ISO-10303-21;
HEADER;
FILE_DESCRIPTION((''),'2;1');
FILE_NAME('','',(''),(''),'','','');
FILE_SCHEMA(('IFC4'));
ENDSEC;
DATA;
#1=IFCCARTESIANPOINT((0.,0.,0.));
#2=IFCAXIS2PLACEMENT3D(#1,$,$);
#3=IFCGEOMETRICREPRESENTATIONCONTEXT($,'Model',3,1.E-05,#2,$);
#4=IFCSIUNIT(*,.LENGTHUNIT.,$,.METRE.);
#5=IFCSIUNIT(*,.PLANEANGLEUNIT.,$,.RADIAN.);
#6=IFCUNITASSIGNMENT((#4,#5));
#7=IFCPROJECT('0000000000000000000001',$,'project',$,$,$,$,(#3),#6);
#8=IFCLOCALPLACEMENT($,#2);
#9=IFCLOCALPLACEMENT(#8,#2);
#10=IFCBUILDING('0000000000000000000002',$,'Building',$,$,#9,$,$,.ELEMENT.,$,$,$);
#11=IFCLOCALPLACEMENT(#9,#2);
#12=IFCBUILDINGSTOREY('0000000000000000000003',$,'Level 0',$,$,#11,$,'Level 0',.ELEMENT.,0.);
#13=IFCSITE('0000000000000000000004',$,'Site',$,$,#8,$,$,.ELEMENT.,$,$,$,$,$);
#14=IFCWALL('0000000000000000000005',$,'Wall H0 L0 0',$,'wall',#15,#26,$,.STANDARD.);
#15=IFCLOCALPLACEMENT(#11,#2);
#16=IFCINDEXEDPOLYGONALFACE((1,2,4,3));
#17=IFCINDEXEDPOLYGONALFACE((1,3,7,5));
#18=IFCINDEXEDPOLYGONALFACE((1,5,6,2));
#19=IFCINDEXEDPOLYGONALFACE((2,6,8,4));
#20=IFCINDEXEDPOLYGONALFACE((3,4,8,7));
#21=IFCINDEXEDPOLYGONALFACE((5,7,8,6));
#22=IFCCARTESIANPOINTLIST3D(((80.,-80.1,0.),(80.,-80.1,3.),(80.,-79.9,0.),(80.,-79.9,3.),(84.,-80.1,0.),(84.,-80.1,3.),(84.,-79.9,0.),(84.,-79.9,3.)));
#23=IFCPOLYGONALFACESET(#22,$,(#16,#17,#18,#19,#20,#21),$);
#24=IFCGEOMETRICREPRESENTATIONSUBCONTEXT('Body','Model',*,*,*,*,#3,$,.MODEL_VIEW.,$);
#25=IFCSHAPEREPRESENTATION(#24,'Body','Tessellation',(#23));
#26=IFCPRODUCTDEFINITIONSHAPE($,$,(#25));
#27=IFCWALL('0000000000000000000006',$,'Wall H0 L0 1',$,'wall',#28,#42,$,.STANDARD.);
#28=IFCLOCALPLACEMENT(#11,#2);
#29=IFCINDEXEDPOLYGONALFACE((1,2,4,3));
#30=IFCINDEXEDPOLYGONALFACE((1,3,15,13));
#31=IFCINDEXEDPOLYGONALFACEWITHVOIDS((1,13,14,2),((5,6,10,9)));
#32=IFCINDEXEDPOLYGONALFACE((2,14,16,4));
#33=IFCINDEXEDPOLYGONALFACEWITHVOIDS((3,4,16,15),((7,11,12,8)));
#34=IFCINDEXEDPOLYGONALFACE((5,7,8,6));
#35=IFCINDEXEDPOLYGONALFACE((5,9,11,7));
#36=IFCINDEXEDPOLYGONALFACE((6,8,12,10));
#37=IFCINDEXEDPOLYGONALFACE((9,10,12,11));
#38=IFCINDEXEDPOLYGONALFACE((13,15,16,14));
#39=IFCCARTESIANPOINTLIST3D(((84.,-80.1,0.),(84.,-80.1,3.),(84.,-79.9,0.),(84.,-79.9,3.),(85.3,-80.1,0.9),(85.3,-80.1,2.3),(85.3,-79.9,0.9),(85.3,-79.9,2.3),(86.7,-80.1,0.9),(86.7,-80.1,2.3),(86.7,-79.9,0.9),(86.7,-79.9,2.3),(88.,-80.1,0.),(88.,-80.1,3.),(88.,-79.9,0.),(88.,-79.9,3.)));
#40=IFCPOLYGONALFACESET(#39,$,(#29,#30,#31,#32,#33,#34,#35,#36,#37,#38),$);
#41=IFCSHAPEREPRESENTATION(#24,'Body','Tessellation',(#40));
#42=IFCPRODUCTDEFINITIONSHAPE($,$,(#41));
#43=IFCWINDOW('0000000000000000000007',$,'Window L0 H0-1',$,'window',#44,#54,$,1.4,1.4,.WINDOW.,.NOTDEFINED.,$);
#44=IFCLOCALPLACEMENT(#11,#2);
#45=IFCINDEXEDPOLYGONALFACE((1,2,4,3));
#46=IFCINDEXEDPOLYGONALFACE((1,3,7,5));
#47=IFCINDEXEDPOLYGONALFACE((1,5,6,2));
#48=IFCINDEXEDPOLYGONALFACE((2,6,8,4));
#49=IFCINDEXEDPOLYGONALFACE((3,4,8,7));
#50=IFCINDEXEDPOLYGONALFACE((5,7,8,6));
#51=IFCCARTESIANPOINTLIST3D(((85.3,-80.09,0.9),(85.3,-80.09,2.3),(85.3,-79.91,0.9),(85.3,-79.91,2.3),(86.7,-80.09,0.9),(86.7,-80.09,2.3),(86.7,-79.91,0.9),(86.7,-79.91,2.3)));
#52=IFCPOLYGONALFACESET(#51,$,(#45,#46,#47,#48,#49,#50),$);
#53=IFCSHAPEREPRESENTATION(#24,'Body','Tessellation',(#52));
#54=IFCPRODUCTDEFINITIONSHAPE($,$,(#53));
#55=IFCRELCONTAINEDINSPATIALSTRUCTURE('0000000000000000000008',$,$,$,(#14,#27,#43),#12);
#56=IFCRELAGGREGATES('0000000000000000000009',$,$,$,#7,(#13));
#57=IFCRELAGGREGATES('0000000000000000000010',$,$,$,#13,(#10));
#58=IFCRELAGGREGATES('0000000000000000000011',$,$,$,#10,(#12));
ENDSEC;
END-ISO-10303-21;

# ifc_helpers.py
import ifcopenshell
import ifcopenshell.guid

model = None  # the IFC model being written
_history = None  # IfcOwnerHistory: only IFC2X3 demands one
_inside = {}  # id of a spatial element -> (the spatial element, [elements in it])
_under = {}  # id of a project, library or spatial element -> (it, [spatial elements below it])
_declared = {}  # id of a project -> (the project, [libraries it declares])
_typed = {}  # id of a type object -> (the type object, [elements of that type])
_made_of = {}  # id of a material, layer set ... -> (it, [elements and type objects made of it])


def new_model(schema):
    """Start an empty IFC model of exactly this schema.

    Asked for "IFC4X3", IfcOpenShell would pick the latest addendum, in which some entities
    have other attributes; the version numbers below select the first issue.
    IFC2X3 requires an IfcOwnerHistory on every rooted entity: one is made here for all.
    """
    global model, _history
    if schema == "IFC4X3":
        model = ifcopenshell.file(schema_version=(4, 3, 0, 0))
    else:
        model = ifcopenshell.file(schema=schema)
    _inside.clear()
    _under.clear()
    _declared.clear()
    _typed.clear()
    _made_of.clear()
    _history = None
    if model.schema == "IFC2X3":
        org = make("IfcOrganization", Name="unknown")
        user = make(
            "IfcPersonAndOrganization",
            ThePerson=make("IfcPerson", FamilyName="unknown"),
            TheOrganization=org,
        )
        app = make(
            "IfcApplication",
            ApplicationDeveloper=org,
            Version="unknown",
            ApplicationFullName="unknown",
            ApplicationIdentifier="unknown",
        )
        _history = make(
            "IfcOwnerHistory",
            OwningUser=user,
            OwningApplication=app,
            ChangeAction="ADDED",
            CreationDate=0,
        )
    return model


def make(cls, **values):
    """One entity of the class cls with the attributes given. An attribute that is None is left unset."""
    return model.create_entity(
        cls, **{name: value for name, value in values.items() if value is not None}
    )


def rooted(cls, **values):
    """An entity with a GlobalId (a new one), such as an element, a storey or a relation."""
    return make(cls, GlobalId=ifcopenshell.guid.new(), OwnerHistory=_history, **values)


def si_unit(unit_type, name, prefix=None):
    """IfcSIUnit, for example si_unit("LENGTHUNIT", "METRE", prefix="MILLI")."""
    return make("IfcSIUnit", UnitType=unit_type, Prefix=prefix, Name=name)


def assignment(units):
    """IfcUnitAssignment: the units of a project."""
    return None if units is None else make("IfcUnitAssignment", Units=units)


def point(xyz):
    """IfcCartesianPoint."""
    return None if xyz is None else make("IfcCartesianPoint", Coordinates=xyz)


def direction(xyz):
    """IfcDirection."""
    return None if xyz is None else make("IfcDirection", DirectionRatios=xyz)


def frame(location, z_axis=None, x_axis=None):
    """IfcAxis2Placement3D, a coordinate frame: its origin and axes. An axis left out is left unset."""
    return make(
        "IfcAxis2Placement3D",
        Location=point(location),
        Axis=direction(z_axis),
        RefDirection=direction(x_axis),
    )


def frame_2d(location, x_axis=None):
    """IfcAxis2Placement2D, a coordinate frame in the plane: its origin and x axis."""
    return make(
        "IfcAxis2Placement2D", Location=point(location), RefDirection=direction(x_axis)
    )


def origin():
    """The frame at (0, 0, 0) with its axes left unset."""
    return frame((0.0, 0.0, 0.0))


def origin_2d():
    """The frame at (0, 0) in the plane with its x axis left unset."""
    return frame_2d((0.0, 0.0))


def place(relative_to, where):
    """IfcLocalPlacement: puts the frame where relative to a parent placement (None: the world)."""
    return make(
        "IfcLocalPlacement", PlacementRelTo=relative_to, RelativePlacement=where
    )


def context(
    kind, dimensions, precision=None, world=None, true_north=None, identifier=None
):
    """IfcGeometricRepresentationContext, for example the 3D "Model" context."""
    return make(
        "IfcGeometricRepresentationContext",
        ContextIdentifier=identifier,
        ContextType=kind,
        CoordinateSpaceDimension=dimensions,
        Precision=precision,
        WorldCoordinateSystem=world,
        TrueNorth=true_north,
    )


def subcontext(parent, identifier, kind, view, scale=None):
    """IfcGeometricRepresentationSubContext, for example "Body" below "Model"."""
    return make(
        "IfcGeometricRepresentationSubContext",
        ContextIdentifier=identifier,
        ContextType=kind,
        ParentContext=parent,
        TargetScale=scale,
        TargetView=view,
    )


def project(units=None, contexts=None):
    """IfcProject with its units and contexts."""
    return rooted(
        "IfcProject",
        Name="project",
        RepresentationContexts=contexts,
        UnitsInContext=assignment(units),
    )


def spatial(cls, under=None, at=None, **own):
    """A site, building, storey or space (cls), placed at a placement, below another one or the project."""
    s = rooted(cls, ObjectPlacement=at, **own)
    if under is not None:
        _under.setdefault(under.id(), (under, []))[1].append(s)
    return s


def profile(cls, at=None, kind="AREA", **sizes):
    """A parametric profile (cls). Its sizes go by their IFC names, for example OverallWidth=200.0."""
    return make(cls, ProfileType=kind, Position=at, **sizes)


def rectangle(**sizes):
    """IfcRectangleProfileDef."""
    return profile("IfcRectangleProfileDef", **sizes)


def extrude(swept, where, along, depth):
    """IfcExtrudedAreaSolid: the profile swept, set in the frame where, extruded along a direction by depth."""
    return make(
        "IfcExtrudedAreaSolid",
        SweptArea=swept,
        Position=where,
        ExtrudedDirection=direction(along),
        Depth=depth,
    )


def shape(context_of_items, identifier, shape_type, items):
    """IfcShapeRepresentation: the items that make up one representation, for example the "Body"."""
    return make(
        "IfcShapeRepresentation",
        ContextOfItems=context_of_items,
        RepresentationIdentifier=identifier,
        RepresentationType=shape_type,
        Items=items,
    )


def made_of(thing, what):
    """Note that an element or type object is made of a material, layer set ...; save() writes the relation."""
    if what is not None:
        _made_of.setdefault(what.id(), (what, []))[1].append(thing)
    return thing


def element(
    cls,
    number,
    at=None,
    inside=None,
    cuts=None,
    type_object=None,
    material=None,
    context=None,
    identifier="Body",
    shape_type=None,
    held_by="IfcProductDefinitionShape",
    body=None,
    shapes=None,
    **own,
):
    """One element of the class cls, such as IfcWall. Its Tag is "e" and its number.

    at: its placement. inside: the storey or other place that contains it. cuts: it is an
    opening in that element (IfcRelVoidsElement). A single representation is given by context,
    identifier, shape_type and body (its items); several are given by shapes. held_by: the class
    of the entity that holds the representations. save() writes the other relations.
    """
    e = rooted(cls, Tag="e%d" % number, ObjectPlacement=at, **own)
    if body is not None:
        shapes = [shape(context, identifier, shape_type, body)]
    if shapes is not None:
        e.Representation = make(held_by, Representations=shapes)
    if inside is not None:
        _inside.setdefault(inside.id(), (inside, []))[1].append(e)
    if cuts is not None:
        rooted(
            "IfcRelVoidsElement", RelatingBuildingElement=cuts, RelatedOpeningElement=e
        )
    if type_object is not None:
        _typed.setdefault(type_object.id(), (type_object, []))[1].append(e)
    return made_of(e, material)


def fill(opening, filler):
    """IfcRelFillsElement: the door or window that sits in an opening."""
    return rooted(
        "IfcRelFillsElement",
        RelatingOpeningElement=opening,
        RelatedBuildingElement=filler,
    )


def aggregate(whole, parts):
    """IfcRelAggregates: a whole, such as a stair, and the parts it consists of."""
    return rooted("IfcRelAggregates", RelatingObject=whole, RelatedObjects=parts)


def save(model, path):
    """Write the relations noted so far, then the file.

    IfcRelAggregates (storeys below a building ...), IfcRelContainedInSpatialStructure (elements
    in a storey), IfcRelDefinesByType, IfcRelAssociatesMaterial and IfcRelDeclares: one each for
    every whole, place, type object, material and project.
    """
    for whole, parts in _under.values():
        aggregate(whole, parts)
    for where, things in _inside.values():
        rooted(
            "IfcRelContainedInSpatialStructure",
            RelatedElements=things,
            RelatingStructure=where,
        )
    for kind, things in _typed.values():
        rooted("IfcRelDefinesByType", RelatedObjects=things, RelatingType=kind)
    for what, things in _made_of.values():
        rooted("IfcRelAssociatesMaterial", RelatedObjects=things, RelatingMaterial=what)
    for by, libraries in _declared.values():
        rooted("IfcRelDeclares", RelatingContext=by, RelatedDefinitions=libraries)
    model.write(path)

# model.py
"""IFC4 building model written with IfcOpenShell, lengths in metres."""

from ifc_helpers import new_model, si_unit, frame, frame_2d, origin, origin_2d, place, context, subcontext, project, spatial, rectangle, extrude, element, fill, save


model = new_model("IFC4")

# Units and contexts
model_context = context("Model", 3, precision=1e-05, world=origin())
body_context = subcontext(model_context, "Body", "Model", "MODEL_VIEW")
ifc_project = project(units=[si_unit("LENGTHUNIT", "METRE"), si_unit("PLANEANGLEUNIT", "RADIAN")], contexts=[model_context])

# Site, building, storey
site_placement = place(None, origin())
site = spatial("IfcSite", under=ifc_project, at=site_placement, Name="Site", CompositionType="ELEMENT")
building_placement = place(site_placement, origin())
building = spatial("IfcBuilding", under=site, at=building_placement, Name="Building", CompositionType="ELEMENT")
storey_placement = place(building_placement, origin())
storey = spatial("IfcBuildingStorey", under=building, at=storey_placement, Name="Level 0", LongName="Level 0", CompositionType="ELEMENT", Elevation=0.0)

# Wall
wall_1_placement = place(storey_placement, frame((80.0, -80.0, 0.0), z_axis=(0.0, 0.0, 1.0), x_axis=(1.0, 0.0, 0.0)))
element("IfcWall", 1, at=wall_1_placement, inside=storey, Name="Wall H0 L0 0", ObjectType="wall", PredefinedType="STANDARD", context=body_context, shape_type="SweptSolid", body=[
    extrude(rectangle(XDim=4.0, YDim=0.2, at=frame_2d((2.0, 0.0))), origin(), (0.0, 0.0, 1.0), 3.0),
])

# Wall, opening, window
wall_2_placement = place(storey_placement, frame((84.0, -80.0, 0.0), z_axis=(0.0, 0.0, 1.0), x_axis=(1.0, 0.0, 0.0)))
wall_2 = element("IfcWall", 2, at=wall_2_placement, inside=storey, Name="Wall H0 L0 1", ObjectType="wall", PredefinedType="STANDARD", context=body_context, shape_type="SweptSolid", body=[
    extrude(rectangle(XDim=4.0, YDim=0.2, at=frame_2d((2.0, 0.0))), origin(), (0.0, 0.0, 1.0), 3.0),
])
opening_placement = place(storey_placement, frame((86.0, -80.0, 0.9), z_axis=(0.0, 0.0, 1.0), x_axis=(1.0, 0.0, 0.0)))
opening = element("IfcOpeningElement", 3, at=opening_placement, cuts=wall_2, ObjectType="Opening", PredefinedType="OPENING", context=body_context, shape_type="SweptSolid", body=[
    extrude(rectangle(XDim=1.4, YDim=0.22, at=origin_2d()), origin(), (0.0, 0.0, 1.0), 1.4),
])
window_placement = place(storey_placement, frame((86.0, -80.0, 0.9), z_axis=(0.0, 0.0, 1.0), x_axis=(1.0, 0.0, 0.0)))
window = element("IfcWindow", 4, at=window_placement, inside=storey, Name="Window L0 H0-1", ObjectType="window", OverallHeight=1.4, OverallWidth=1.4, PartitioningType="NOTDEFINED", PredefinedType="WINDOW", context=body_context, shape_type="SweptSolid", body=[
    extrude(rectangle(XDim=1.4, YDim=0.18, at=origin_2d()), origin(), (0.0, 0.0, 1.0), 1.4),
])
fill(opening, window)

save(model, "model.ifc")
